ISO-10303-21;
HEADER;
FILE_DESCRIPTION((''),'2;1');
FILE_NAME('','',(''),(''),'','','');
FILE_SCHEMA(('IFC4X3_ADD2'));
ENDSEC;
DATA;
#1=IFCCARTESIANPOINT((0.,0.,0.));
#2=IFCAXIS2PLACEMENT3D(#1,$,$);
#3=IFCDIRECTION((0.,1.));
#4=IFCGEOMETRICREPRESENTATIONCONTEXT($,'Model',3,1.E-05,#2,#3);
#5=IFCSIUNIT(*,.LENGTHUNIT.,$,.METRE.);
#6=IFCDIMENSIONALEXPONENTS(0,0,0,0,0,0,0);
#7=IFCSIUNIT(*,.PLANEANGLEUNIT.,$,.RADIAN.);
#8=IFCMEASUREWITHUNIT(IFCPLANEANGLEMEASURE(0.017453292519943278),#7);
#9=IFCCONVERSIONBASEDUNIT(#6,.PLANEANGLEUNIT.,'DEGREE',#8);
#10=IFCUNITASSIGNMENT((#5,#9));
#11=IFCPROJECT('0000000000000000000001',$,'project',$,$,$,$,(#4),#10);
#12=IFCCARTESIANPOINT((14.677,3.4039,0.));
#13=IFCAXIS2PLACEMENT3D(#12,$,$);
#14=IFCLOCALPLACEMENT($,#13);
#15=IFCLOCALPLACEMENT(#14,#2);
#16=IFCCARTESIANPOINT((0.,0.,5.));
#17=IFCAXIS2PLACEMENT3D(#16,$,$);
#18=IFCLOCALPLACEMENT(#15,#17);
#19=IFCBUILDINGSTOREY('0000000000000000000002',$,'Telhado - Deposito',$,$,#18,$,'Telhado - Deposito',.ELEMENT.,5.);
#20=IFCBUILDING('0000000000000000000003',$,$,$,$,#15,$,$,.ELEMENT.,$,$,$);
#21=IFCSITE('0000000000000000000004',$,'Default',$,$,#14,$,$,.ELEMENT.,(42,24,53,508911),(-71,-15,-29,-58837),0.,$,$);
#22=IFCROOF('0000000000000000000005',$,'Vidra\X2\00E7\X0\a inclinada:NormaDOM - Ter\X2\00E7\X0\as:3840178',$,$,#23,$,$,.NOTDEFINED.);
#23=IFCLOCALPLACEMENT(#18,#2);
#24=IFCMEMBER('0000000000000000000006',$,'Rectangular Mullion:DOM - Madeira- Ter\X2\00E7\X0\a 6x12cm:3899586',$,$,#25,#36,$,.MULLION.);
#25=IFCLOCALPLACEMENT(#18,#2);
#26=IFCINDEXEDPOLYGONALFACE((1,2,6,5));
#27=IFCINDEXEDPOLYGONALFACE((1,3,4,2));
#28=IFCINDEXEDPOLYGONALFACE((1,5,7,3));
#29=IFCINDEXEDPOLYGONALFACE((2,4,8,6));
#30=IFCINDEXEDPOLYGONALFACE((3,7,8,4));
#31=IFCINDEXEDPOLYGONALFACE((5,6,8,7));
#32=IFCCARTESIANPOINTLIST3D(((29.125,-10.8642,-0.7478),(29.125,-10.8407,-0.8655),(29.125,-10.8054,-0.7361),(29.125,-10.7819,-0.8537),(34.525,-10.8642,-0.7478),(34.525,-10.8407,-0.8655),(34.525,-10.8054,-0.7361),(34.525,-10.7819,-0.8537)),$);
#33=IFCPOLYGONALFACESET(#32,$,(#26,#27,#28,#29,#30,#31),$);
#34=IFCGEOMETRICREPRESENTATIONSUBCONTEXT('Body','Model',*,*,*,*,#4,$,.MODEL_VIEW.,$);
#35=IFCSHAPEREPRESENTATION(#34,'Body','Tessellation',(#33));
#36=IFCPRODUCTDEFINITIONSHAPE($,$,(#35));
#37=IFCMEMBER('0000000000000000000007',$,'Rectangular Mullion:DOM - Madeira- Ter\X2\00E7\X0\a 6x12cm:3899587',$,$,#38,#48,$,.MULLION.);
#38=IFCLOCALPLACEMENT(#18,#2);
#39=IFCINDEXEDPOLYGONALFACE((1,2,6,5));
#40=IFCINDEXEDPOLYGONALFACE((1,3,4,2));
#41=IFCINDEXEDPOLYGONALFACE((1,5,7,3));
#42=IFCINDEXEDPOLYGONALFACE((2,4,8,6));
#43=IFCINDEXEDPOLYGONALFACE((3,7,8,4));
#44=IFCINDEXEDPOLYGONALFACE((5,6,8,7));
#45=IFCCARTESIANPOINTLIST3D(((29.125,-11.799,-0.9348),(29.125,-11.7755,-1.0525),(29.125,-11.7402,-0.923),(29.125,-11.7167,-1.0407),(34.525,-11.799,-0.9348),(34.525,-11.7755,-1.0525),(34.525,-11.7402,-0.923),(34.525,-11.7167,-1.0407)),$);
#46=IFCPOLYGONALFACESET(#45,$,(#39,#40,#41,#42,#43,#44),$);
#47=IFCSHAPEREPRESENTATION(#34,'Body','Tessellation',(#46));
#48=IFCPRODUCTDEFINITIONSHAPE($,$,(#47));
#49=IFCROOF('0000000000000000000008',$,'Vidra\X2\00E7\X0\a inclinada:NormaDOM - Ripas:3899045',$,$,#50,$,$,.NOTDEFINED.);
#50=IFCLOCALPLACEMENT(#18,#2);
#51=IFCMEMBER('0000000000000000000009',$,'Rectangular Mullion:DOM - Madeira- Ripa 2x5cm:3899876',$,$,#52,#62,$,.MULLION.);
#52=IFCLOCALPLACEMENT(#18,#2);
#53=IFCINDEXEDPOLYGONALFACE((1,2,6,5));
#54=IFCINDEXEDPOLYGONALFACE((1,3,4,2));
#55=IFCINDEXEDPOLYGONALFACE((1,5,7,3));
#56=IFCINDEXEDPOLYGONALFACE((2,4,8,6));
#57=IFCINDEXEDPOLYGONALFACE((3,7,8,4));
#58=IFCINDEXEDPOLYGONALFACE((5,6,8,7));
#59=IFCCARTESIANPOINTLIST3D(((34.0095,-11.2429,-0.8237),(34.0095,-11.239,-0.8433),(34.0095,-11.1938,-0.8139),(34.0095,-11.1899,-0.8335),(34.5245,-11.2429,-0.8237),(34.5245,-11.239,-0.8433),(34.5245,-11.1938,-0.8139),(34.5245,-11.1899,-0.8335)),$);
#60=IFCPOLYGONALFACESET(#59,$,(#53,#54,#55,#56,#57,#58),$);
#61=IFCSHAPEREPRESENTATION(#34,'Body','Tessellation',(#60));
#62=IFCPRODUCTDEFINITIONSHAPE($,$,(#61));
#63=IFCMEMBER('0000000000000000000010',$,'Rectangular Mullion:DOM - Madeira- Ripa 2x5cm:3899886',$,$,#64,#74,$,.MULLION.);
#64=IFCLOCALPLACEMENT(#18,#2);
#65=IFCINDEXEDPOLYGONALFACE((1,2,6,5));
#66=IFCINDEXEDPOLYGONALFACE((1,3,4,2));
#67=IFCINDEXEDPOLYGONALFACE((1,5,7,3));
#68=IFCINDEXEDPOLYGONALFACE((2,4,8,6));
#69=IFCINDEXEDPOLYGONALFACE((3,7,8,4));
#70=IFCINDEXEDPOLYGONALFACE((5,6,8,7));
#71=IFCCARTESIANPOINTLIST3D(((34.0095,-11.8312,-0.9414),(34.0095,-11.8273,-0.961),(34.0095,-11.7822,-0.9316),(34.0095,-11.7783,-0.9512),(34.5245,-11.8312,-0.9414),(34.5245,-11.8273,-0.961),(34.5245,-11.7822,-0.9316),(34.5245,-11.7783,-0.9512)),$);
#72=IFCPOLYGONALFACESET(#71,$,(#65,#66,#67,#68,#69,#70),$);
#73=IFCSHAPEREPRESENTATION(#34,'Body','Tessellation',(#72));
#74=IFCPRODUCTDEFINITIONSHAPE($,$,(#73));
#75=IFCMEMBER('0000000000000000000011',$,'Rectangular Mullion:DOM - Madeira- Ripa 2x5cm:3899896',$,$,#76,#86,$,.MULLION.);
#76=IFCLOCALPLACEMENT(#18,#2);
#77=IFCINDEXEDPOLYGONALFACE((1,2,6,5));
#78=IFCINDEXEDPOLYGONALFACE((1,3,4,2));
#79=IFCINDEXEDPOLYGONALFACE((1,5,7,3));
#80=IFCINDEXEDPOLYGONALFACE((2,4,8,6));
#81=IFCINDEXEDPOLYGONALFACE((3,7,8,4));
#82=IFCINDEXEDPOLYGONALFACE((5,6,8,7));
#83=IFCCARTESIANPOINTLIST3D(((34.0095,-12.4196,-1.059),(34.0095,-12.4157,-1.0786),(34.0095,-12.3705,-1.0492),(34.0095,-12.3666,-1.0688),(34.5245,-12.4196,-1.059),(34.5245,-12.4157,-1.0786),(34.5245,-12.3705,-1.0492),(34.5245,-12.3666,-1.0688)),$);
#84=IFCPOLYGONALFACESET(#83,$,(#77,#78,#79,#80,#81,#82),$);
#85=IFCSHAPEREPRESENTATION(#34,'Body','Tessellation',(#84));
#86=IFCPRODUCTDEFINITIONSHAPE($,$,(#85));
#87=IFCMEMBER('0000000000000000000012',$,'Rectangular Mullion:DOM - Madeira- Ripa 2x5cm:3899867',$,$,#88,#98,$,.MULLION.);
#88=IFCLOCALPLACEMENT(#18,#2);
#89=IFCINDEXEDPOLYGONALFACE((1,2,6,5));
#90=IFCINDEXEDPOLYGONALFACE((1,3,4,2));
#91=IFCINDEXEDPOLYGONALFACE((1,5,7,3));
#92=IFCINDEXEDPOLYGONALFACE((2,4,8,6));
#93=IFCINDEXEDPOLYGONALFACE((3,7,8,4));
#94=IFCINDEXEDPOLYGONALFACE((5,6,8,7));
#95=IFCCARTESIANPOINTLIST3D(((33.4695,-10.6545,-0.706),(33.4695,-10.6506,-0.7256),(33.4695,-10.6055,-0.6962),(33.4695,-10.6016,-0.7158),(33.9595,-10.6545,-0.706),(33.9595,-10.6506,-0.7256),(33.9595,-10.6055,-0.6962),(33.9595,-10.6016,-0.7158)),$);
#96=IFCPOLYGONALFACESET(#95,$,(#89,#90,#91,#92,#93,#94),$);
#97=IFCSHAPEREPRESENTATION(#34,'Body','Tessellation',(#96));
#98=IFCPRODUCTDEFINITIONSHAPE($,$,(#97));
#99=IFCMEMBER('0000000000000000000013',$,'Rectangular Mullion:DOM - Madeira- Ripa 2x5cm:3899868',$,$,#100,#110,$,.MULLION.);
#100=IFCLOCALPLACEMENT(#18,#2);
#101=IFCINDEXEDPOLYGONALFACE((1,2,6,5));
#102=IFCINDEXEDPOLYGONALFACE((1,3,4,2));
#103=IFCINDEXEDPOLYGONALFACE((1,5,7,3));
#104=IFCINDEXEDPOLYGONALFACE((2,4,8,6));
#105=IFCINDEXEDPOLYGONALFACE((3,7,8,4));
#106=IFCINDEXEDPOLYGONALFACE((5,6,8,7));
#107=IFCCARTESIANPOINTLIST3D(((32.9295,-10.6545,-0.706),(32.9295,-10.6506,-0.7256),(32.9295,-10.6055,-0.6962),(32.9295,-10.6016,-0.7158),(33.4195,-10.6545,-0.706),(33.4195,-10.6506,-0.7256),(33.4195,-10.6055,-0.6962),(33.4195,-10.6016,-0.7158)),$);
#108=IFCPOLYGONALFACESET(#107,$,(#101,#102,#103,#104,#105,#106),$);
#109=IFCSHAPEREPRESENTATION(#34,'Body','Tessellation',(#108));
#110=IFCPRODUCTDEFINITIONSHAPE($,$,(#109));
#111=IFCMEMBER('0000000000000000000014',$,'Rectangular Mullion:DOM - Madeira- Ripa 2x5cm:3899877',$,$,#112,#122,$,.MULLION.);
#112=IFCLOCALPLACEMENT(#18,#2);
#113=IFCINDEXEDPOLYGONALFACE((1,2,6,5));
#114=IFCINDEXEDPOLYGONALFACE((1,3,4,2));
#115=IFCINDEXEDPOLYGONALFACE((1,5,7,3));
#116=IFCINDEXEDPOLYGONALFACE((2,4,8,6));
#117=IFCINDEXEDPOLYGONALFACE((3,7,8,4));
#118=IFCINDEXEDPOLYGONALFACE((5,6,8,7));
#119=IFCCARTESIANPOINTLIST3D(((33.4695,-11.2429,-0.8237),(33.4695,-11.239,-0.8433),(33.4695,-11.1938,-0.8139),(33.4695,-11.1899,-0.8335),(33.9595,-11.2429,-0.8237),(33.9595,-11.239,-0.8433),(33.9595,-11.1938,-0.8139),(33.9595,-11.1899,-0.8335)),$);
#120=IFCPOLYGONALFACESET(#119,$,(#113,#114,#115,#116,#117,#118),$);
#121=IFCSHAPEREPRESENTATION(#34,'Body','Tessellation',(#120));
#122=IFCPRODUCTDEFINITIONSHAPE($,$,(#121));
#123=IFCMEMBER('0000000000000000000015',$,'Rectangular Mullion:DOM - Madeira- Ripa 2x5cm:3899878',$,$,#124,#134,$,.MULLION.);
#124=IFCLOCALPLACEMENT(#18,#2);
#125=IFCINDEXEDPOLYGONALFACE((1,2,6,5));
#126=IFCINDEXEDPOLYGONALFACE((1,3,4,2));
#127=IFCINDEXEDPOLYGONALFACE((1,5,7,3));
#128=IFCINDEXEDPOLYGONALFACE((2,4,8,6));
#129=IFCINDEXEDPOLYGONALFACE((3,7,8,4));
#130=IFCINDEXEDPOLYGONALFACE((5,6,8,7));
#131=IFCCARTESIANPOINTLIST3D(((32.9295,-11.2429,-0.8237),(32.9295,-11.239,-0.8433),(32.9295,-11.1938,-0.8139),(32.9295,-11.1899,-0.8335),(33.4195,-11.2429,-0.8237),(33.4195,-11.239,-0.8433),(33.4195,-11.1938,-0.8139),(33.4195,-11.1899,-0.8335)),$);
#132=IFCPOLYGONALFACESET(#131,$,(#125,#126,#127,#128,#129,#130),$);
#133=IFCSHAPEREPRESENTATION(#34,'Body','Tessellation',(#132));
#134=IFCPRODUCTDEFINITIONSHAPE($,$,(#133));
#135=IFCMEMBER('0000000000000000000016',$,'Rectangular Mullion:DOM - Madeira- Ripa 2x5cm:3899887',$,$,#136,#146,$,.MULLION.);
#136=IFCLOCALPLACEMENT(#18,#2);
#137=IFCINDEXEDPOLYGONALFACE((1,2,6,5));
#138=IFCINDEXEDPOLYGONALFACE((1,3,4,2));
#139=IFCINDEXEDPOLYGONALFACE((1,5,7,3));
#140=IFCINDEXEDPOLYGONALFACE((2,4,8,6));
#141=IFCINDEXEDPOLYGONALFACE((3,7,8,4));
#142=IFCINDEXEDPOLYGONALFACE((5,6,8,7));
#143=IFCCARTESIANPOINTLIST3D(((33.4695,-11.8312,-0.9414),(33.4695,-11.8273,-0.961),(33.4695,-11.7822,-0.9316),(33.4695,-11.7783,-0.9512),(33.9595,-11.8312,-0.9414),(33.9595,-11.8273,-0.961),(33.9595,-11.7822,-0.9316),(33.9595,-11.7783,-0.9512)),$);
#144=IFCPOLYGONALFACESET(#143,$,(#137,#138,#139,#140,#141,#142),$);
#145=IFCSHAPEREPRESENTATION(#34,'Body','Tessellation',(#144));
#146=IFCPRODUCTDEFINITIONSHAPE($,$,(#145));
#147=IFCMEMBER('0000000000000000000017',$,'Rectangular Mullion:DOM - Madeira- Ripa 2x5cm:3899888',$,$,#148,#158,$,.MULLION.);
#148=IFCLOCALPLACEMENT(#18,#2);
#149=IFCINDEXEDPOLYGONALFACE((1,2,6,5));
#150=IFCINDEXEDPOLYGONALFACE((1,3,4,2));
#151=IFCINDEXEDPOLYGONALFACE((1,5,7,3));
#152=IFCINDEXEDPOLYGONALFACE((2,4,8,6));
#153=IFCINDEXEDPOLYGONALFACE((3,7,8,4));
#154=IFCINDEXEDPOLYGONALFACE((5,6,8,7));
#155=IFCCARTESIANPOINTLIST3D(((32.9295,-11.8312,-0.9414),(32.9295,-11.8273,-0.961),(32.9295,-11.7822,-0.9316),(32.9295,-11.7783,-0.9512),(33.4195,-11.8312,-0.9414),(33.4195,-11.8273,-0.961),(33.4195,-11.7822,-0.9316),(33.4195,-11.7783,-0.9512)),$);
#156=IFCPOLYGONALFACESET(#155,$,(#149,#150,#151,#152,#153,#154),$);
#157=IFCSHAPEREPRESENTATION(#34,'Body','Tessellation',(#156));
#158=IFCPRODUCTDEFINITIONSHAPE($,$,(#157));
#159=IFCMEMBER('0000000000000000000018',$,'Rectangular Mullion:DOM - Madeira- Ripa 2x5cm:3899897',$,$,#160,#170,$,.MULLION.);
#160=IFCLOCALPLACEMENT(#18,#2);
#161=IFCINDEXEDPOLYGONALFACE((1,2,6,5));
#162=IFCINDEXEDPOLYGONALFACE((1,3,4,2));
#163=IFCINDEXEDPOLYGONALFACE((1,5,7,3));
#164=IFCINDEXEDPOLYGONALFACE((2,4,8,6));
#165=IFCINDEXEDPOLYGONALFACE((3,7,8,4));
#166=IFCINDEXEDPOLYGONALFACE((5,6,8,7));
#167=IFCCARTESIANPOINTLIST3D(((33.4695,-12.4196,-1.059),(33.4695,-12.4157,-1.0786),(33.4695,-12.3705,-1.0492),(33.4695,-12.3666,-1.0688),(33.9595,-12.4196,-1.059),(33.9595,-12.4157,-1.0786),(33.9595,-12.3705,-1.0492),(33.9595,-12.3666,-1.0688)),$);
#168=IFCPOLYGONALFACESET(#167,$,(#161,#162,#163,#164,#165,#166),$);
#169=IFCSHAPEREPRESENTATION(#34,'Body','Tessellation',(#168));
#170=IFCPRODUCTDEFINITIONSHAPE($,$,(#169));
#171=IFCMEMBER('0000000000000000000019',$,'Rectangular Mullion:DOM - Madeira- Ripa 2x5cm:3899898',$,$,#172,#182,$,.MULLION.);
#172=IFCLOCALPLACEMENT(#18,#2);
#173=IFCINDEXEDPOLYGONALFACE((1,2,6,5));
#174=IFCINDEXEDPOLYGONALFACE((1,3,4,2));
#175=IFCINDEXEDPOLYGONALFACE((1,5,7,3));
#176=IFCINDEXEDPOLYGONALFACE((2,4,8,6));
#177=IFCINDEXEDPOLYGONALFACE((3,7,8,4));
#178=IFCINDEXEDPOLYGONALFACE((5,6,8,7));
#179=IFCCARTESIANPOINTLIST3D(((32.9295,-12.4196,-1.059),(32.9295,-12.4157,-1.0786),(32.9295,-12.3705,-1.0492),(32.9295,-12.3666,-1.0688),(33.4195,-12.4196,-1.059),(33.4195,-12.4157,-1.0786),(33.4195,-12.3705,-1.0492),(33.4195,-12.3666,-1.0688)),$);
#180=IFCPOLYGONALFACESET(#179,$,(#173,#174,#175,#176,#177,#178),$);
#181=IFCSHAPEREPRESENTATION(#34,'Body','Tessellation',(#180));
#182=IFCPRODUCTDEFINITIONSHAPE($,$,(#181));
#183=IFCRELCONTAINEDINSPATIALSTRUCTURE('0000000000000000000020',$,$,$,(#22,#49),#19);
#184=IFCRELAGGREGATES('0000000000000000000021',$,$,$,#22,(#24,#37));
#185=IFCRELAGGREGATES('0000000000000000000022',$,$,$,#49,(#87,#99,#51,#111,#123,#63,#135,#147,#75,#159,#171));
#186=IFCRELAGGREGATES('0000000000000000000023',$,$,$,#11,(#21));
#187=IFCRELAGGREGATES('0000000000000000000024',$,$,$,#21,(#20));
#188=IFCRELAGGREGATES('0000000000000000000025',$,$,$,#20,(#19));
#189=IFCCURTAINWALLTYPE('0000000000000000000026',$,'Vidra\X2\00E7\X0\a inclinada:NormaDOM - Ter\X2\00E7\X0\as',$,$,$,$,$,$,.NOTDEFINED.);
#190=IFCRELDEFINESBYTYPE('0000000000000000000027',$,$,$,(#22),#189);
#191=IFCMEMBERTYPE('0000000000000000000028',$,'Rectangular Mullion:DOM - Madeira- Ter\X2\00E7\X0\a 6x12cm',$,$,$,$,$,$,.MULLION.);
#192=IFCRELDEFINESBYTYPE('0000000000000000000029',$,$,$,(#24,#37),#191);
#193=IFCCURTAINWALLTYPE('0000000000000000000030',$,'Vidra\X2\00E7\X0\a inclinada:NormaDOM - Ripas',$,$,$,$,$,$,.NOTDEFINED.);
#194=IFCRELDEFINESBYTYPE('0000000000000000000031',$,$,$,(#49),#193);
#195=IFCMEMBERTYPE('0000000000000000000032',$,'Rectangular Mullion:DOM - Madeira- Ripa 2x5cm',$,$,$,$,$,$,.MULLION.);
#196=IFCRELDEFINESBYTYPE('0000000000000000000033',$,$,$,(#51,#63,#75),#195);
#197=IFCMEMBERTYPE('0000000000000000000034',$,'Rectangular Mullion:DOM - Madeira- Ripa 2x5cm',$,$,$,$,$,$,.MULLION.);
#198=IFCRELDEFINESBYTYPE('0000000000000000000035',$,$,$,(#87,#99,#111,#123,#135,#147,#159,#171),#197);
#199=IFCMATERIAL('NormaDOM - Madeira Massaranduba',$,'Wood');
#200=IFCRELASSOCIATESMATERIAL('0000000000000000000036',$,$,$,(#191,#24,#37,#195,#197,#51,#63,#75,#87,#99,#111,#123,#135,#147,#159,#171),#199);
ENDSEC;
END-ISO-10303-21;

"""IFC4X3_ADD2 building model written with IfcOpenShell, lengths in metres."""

from ifc_helpers import new_model, entity, si_unit, converted_unit, direction, frame, origin, origin_2d_with_axis, place, context, subcontext, project, spatial, rectangle, extrude, source, transform, mapped, material, material_profile, profile_set, profile_usage, type_object, type_shapes, element, aggregate, save


model = new_model("IFC4X3_ADD2")

# Units and contexts
model_context = context("Model", 3, precision=1e-05, world=origin(), true_north=direction((0.0, 1.0)))
body_context = subcontext(model_context, "Body", "Model", "MODEL_VIEW")
ifc_project = project(units=[si_unit("LENGTHUNIT", "METRE"), converted_unit("PLANEANGLEUNIT", "DEGREE", entity("IfcPlaneAngleMeasure", 0.017453292519943278), si_unit("PLANEANGLEUNIT", "RADIAN"), dimensions=[0, 0, 0, 0, 0, 0, 0])], contexts=[model_context])

# Site, building, storey
site_placement = place(None, frame((14.677, 3.4039, 0.0)))
site = spatial("IfcSite", under=ifc_project, at=site_placement, Name="Default", CompositionType="ELEMENT", RefLatitude=(42, 24, 53, 508911), RefLongitude=(-71, -15, -29, -58837), RefElevation=0.0)
building_placement = place(site_placement, origin())
building = spatial("IfcBuilding", under=site, at=building_placement, CompositionType="ELEMENT")
storey_placement = place(building_placement, frame((0.0, 0.0, 5.0)))
storey = spatial("IfcBuildingStorey", under=building, at=storey_placement, Name="Telhado - Deposito", LongName="Telhado - Deposito", CompositionType="ELEMENT", Elevation=5.0)

# Roofs, members
curtain_wall_type_1 = type_object("IfcCurtainWallType", Name="Vidraça inclinada:NormaDOM - Terças", PredefinedType="NOTDEFINED")
roof_1_placement = place(storey_placement, frame((0.0, 0.0, -5.0)))
roof_1 = element("IfcRoof", 1, at=roof_1_placement, inside=storey, type_object=curtain_wall_type_1, Name="Vidraça inclinada:NormaDOM - Terças:3840178", PredefinedType="NOTDEFINED")
ifc_material = material(Name="NormaDOM - Madeira Massaranduba", Category="Wood")
ifc_material_profile_1 = material_profile(ifc_material, rectangle(XDim=0.06, YDim=0.12, at=origin_2d_with_axis()), Name="DOM - Madeira- Terça 6x12cm")
ifc_profile_set_1 = profile_set([ifc_material_profile_1], Name="DOM - Madeira- Terça 6x12cm")
ifc_profile_usage_1 = profile_usage(ifc_profile_set_1)
member_type_1 = type_object("IfcMemberType", Name="Rectangular Mullion:DOM - Madeira- Terça 6x12cm", PredefinedType="MULLION", material=ifc_profile_set_1)
shared_shape_1 = source(origin(), body_context, "Body", "SweptSolid", [
    extrude(rectangle(XDim=0.06, YDim=0.12, at=origin_2d_with_axis()), frame((0.0, 0.06, -5.4), z_axis=(0.0, 0.0, 1.0), x_axis=(-1.0, 0.0, 0.0)), (0.0, 0.0, 1.0), 5.4),
])
type_shapes(member_type_1, [shared_shape_1])
member_1_placement = place(roof_1_placement, frame((34.525, -10.8348, 4.258), z_axis=(1.0, 0.0, 0.0), x_axis=(0.0, -0.980581, -0.196116)))
member_1 = element("IfcMember", 2, at=member_1_placement, type_object=member_type_1, material=ifc_profile_usage_1, Name="Rectangular Mullion:DOM - Madeira- Terça 6x12cm:3899586", PredefinedType="MULLION", context=body_context, shape_type="MappedRepresentation", body=[
    mapped(shared_shape_1, transform((0.0, 0.0, 0.0), scale=1.0)),
])
member_2_placement = place(roof_1_placement, frame((34.525, -11.7696, 4.0711), z_axis=(1.0, 0.0, 0.0), x_axis=(0.0, -0.980581, -0.196116)))
member_2 = element("IfcMember", 3, at=member_2_placement, type_object=member_type_1, material=ifc_profile_usage_1, Name="Rectangular Mullion:DOM - Madeira- Terça 6x12cm:3899587", PredefinedType="MULLION", context=body_context, shape_type="MappedRepresentation", body=[
    mapped(shared_shape_1, transform((0.0, 0.0, 0.0), scale=1.0)),
])
aggregate(roof_1, [member_1, member_2])
curtain_wall_type_2 = type_object("IfcCurtainWallType", Name="Vidraça inclinada:NormaDOM - Ripas", PredefinedType="NOTDEFINED")
roof_2_placement = place(storey_placement, frame((0.0, 0.0, -5.0)))
roof_2 = element("IfcRoof", 4, at=roof_2_placement, inside=storey, type_object=curtain_wall_type_2, Name="Vidraça inclinada:NormaDOM - Ripas:3899045", PredefinedType="NOTDEFINED")
ifc_material_profile_2 = material_profile(ifc_material, rectangle(XDim=0.05, YDim=0.02, at=origin_2d_with_axis()), Name="DOM - Madeira- Ripa 2x5cm")
ifc_profile_set_2 = profile_set([ifc_material_profile_2], Name="DOM - Madeira- Ripa 2x5cm")
ifc_profile_usage_2 = profile_usage(ifc_profile_set_2)
member_type_2 = type_object("IfcMemberType", Name="Rectangular Mullion:DOM - Madeira- Ripa 2x5cm", PredefinedType="MULLION", material=ifc_profile_set_2)
shared_shape_2 = source(origin(), body_context, "Body", "SweptSolid", [
    extrude(rectangle(XDim=0.05, YDim=0.02, at=origin_2d_with_axis()), frame((0.025, 0.01, -0.515), z_axis=(0.0, 0.0, 1.0), x_axis=(-1.0, 0.0, 0.0)), (0.0, 0.0, 1.0), 0.515),
])
type_shapes(member_type_2, [shared_shape_2])
member_3_placement = place(roof_2_placement, frame((34.5245, -11.1938, 4.1861), z_axis=(1.0, 0.0, 0.0), x_axis=(0.0, -0.980581, -0.196116)))
member_3 = element("IfcMember", 5, at=member_3_placement, type_object=member_type_2, material=ifc_profile_usage_2, Name="Rectangular Mullion:DOM - Madeira- Ripa 2x5cm:3899876", PredefinedType="MULLION", context=body_context, shape_type="MappedRepresentation", body=[
    mapped(shared_shape_2, transform((0.0, 0.0, 0.0), scale=1.0)),
])
member_4_placement = place(roof_2_placement, frame((34.5245, -11.7822, 4.0684), z_axis=(1.0, 0.0, 0.0), x_axis=(0.0, -0.980581, -0.196116)))
member_4 = element("IfcMember", 6, at=member_4_placement, type_object=member_type_2, material=ifc_profile_usage_2, Name="Rectangular Mullion:DOM - Madeira- Ripa 2x5cm:3899886", PredefinedType="MULLION", context=body_context, shape_type="MappedRepresentation", body=[
    mapped(shared_shape_2, transform((0.0, 0.0, 0.0), scale=1.0)),
])
member_5_placement = place(roof_2_placement, frame((34.5245, -12.3705, 3.9508), z_axis=(1.0, 0.0, 0.0), x_axis=(0.0, -0.980581, -0.196116)))
member_5 = element("IfcMember", 7, at=member_5_placement, type_object=member_type_2, material=ifc_profile_usage_2, Name="Rectangular Mullion:DOM - Madeira- Ripa 2x5cm:3899896", PredefinedType="MULLION", context=body_context, shape_type="MappedRepresentation", body=[
    mapped(shared_shape_2, transform((0.0, 0.0, 0.0), scale=1.0)),
])
member_type_3 = type_object("IfcMemberType", Name="Rectangular Mullion:DOM - Madeira- Ripa 2x5cm", PredefinedType="MULLION", material=ifc_profile_set_2)
shared_shape_3 = source(origin(), body_context, "Body", "SweptSolid", [
    extrude(rectangle(XDim=0.05, YDim=0.02, at=origin_2d_with_axis()), frame((0.025, 0.01, -0.49), z_axis=(0.0, 0.0, 1.0), x_axis=(-1.0, 0.0, 0.0)), (0.0, 0.0, 1.0), 0.49),
])
type_shapes(member_type_3, [shared_shape_3])
member_6_placement = place(roof_2_placement, frame((33.9595, -10.6055, 4.3038), z_axis=(1.0, 0.0, 0.0), x_axis=(0.0, -0.980581, -0.196116)))
member_6 = element("IfcMember", 8, at=member_6_placement, type_object=member_type_3, material=ifc_profile_usage_2, Name="Rectangular Mullion:DOM - Madeira- Ripa 2x5cm:3899867", PredefinedType="MULLION", context=body_context, shape_type="MappedRepresentation", body=[
    mapped(shared_shape_3, transform((0.0, 0.0, 0.0), scale=1.0)),
])
member_7_placement = place(roof_2_placement, frame((33.4195, -10.6055, 4.3038), z_axis=(1.0, 0.0, 0.0), x_axis=(0.0, -0.980581, -0.196116)))
member_7 = element("IfcMember", 9, at=member_7_placement, type_object=member_type_3, material=ifc_profile_usage_2, Name="Rectangular Mullion:DOM - Madeira- Ripa 2x5cm:3899868", PredefinedType="MULLION", context=body_context, shape_type="MappedRepresentation", body=[
    mapped(shared_shape_3, transform((0.0, 0.0, 0.0), scale=1.0)),
])
member_8_placement = place(roof_2_placement, frame((33.9595, -11.1938, 4.1861), z_axis=(1.0, 0.0, 0.0), x_axis=(0.0, -0.980581, -0.196116)))
member_8 = element("IfcMember", 10, at=member_8_placement, type_object=member_type_3, material=ifc_profile_usage_2, Name="Rectangular Mullion:DOM - Madeira- Ripa 2x5cm:3899877", PredefinedType="MULLION", context=body_context, shape_type="MappedRepresentation", body=[
    mapped(shared_shape_3, transform((0.0, 0.0, 0.0), scale=1.0)),
])
member_9_placement = place(roof_2_placement, frame((33.4195, -11.1938, 4.1861), z_axis=(1.0, 0.0, 0.0), x_axis=(0.0, -0.980581, -0.196116)))
member_9 = element("IfcMember", 11, at=member_9_placement, type_object=member_type_3, material=ifc_profile_usage_2, Name="Rectangular Mullion:DOM - Madeira- Ripa 2x5cm:3899878", PredefinedType="MULLION", context=body_context, shape_type="MappedRepresentation", body=[
    mapped(shared_shape_3, transform((0.0, 0.0, 0.0), scale=1.0)),
])
member_10_placement = place(roof_2_placement, frame((33.9595, -11.7822, 4.0684), z_axis=(1.0, 0.0, 0.0), x_axis=(0.0, -0.980581, -0.196116)))
member_10 = element("IfcMember", 12, at=member_10_placement, type_object=member_type_3, material=ifc_profile_usage_2, Name="Rectangular Mullion:DOM - Madeira- Ripa 2x5cm:3899887", PredefinedType="MULLION", context=body_context, shape_type="MappedRepresentation", body=[
    mapped(shared_shape_3, transform((0.0, 0.0, 0.0), scale=1.0)),
])
member_11_placement = place(roof_2_placement, frame((33.4195, -11.7822, 4.0684), z_axis=(1.0, 0.0, 0.0), x_axis=(0.0, -0.980581, -0.196116)))
member_11 = element("IfcMember", 13, at=member_11_placement, type_object=member_type_3, material=ifc_profile_usage_2, Name="Rectangular Mullion:DOM - Madeira- Ripa 2x5cm:3899888", PredefinedType="MULLION", context=body_context, shape_type="MappedRepresentation", body=[
    mapped(shared_shape_3, transform((0.0, 0.0, 0.0), scale=1.0)),
])
member_12_placement = place(roof_2_placement, frame((33.9595, -12.3705, 3.9508), z_axis=(1.0, 0.0, 0.0), x_axis=(0.0, -0.980581, -0.196116)))
member_12 = element("IfcMember", 14, at=member_12_placement, type_object=member_type_3, material=ifc_profile_usage_2, Name="Rectangular Mullion:DOM - Madeira- Ripa 2x5cm:3899897", PredefinedType="MULLION", context=body_context, shape_type="MappedRepresentation", body=[
    mapped(shared_shape_3, transform((0.0, 0.0, 0.0), scale=1.0)),
])
member_13_placement = place(roof_2_placement, frame((33.4195, -12.3705, 3.9508), z_axis=(1.0, 0.0, 0.0), x_axis=(0.0, -0.980581, -0.196116)))
member_13 = element("IfcMember", 15, at=member_13_placement, type_object=member_type_3, material=ifc_profile_usage_2, Name="Rectangular Mullion:DOM - Madeira- Ripa 2x5cm:3899898", PredefinedType="MULLION", context=body_context, shape_type="MappedRepresentation", body=[
    mapped(shared_shape_3, transform((0.0, 0.0, 0.0), scale=1.0)),
])
aggregate(roof_2, [member_6, member_7, member_3, member_8, member_9, member_4, member_10, member_11, member_5, member_12, member_13])

save(model, "model.ifc")
